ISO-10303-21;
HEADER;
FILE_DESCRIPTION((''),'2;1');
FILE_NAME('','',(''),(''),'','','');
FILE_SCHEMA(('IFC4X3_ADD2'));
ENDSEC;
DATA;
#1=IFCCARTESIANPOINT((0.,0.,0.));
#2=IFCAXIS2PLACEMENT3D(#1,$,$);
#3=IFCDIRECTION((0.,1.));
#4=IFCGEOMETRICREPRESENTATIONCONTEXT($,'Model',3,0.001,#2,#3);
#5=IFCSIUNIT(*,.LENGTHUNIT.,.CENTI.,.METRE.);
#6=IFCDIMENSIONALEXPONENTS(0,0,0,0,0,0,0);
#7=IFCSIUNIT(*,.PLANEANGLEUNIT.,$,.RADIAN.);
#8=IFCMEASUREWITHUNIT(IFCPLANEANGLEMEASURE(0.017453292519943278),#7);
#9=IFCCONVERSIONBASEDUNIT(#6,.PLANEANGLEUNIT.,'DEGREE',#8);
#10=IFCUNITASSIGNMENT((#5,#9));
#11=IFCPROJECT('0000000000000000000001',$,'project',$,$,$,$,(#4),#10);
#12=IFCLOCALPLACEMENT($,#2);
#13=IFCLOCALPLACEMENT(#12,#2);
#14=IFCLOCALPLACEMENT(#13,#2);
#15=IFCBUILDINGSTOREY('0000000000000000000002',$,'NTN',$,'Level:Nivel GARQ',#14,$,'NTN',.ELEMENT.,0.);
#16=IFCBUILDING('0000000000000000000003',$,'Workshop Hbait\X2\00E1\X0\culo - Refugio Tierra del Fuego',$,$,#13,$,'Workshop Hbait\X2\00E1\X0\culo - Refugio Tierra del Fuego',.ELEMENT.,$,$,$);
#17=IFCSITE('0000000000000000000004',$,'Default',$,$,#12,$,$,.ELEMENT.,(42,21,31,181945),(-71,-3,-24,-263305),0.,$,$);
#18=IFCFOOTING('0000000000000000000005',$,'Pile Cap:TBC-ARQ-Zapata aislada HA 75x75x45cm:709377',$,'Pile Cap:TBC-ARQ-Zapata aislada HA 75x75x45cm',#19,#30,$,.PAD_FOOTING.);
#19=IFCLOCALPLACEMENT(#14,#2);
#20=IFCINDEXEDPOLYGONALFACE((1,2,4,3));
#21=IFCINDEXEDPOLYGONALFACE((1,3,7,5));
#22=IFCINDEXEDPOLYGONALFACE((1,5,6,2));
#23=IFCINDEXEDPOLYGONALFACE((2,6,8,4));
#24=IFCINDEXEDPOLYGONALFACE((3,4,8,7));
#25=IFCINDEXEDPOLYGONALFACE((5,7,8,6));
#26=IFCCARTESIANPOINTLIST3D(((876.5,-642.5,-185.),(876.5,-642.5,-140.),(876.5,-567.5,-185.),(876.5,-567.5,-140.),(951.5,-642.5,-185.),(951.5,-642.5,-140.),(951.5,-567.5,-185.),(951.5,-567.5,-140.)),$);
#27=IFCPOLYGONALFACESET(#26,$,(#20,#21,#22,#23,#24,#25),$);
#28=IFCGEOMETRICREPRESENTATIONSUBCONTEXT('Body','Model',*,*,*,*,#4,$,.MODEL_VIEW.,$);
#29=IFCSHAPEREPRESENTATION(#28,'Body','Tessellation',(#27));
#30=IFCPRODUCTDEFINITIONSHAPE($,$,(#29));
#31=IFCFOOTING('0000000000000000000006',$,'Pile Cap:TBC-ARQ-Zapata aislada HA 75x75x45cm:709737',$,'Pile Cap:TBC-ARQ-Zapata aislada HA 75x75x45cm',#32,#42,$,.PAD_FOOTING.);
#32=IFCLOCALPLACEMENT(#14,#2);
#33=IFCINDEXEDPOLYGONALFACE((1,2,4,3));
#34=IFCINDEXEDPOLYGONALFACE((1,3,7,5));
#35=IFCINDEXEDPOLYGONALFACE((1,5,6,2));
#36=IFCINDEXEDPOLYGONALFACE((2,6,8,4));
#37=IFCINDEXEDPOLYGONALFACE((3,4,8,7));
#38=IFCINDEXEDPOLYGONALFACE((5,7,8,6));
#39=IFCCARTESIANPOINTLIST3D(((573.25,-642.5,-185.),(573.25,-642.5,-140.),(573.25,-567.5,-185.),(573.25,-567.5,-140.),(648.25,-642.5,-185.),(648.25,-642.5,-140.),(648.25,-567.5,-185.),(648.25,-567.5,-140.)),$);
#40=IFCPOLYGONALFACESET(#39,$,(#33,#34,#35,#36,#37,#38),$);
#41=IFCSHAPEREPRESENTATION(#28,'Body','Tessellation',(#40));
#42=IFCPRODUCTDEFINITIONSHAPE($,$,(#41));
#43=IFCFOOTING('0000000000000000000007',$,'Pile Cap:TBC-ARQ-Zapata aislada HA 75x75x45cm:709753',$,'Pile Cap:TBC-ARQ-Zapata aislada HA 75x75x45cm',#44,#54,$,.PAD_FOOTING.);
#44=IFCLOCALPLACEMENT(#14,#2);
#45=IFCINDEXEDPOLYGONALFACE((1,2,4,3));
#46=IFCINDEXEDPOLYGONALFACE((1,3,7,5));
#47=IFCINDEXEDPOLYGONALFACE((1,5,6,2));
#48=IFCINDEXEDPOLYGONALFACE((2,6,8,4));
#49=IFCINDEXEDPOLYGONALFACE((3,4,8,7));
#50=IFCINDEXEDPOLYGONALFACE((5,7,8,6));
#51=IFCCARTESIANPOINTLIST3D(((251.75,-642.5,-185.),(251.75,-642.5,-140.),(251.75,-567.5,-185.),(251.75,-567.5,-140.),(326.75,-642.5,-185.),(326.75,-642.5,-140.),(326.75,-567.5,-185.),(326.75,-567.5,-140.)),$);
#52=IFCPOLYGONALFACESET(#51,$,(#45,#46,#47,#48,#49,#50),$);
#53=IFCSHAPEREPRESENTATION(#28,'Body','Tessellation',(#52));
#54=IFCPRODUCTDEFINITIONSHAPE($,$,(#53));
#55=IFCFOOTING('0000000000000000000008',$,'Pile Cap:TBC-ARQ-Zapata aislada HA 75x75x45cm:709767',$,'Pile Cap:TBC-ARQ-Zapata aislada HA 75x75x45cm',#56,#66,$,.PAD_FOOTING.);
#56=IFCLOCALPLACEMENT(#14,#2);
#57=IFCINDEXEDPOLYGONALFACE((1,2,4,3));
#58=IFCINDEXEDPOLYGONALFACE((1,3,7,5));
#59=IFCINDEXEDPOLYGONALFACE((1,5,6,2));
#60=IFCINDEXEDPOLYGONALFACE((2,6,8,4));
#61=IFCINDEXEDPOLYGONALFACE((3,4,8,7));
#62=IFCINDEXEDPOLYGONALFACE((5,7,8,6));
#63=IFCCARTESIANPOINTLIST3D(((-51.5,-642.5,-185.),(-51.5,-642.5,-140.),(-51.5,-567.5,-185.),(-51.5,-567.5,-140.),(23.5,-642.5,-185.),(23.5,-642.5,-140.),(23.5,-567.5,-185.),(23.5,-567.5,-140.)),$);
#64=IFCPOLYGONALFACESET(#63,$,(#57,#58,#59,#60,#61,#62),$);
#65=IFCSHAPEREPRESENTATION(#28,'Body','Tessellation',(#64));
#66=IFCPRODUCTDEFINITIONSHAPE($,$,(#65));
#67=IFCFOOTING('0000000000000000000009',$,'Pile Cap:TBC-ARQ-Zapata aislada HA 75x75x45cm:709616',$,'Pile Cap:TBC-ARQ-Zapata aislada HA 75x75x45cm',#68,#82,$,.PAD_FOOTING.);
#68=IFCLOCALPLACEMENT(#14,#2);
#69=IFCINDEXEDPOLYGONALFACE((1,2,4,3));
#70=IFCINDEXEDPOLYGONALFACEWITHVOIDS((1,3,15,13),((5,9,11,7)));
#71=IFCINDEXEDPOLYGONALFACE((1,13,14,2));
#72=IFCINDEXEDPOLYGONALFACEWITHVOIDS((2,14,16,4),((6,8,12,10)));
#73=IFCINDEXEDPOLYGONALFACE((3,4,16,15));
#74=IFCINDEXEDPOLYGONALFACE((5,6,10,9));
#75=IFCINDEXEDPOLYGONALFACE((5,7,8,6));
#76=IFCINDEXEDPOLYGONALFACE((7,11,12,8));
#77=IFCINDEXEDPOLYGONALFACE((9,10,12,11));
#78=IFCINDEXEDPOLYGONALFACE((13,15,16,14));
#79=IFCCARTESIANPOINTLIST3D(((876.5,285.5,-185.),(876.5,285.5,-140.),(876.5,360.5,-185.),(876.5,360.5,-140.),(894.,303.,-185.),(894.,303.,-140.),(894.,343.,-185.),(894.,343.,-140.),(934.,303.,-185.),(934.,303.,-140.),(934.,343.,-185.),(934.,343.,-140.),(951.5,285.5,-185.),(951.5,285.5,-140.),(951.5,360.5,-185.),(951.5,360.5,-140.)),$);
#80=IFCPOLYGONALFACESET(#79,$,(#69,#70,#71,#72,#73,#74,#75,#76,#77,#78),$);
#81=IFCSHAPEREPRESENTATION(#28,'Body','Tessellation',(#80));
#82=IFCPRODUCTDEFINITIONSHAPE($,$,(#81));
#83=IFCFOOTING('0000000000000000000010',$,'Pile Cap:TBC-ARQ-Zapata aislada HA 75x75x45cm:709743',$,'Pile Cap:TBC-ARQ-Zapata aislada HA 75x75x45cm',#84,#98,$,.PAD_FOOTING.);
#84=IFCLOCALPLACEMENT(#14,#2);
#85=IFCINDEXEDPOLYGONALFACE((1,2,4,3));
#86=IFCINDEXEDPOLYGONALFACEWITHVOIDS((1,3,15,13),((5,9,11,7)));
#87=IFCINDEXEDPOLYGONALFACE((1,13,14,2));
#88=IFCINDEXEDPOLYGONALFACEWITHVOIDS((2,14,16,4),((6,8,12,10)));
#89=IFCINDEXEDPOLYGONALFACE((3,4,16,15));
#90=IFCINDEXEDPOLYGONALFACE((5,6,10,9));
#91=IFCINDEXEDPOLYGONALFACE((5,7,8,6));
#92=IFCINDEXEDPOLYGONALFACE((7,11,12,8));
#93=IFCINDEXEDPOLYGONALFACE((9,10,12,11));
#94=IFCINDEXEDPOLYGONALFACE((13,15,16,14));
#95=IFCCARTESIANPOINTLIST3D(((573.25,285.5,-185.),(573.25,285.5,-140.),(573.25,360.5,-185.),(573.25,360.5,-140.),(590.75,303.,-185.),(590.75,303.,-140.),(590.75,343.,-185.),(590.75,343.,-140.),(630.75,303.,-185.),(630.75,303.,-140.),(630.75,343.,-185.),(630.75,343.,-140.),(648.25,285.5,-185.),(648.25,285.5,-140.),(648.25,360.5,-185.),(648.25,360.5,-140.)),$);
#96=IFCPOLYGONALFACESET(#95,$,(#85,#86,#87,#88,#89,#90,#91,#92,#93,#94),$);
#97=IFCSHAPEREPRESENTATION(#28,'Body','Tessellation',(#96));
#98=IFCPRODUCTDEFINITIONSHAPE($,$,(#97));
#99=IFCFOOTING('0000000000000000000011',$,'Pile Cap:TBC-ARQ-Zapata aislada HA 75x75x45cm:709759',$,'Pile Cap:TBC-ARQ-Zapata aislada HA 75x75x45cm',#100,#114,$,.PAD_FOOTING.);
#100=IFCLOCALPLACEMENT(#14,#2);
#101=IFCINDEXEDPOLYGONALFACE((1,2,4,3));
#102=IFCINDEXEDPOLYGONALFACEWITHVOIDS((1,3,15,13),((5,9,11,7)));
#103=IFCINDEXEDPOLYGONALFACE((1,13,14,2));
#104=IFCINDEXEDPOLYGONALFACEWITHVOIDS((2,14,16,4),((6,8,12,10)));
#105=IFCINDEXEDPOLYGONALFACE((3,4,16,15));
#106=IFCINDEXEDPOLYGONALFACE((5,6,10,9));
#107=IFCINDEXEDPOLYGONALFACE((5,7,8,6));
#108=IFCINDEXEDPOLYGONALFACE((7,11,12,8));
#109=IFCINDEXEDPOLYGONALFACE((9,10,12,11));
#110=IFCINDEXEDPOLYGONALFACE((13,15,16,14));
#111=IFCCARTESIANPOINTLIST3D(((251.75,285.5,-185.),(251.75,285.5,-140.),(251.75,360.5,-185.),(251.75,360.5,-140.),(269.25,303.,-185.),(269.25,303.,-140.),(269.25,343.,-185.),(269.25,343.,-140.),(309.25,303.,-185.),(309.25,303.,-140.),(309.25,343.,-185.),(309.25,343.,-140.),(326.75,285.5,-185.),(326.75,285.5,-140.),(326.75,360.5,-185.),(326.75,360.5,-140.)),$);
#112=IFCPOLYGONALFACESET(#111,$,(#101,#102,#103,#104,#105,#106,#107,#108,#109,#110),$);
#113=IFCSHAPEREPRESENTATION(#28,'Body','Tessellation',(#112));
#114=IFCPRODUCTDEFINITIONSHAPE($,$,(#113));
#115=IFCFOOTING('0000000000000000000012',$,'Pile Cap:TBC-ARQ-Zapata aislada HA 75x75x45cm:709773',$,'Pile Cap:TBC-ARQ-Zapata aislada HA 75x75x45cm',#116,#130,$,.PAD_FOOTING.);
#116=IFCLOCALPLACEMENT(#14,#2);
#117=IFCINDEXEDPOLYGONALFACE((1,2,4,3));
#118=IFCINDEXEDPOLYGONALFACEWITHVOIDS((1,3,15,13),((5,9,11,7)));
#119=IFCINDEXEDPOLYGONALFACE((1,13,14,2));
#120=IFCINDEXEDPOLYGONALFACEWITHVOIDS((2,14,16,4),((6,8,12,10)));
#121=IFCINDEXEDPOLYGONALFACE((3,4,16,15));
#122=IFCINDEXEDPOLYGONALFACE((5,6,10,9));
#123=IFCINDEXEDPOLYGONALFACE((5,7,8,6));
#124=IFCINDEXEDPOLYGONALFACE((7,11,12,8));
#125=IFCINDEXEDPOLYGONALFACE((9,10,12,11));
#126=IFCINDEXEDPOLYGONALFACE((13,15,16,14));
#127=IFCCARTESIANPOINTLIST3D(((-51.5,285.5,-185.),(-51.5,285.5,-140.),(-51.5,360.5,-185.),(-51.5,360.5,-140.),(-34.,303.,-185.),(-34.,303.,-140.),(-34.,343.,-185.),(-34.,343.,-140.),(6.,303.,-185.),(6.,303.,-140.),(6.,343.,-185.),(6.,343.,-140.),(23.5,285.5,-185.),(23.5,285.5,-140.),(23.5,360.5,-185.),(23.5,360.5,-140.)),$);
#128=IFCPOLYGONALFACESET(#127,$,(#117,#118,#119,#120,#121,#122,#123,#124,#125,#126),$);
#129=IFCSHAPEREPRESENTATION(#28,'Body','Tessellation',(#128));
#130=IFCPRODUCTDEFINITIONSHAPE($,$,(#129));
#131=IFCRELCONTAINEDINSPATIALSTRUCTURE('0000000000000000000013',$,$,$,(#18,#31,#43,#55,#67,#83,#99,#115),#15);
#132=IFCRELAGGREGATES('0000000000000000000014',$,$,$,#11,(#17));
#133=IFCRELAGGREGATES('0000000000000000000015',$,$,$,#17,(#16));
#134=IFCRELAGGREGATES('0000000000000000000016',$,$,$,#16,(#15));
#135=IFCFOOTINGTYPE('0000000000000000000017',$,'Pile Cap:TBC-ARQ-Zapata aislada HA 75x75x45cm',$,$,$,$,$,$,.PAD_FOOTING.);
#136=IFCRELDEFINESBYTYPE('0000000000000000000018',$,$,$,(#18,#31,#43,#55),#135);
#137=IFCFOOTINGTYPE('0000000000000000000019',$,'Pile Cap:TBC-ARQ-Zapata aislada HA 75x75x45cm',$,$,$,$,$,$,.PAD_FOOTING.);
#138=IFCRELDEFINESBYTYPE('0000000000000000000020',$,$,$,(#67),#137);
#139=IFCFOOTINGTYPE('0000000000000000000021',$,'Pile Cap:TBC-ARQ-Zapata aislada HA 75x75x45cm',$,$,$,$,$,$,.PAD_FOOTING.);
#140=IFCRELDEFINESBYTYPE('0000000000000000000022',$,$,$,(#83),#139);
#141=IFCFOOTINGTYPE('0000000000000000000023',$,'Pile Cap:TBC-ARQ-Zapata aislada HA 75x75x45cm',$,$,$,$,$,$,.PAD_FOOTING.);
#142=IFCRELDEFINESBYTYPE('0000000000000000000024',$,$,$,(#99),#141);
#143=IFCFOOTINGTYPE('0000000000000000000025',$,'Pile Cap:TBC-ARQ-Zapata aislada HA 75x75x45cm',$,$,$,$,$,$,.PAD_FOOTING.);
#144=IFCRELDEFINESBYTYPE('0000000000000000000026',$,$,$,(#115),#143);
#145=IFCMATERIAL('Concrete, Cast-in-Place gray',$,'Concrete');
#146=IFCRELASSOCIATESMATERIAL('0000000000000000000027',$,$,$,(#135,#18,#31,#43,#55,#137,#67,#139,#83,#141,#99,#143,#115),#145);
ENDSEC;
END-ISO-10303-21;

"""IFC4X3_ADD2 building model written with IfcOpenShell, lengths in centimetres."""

from ifc_helpers import new_model, entity, si_unit, converted_unit, direction, frame, origin, origin_2d_with_axis, place, context, subcontext, project, spatial, polyline, rectangle, outline, extrude, source, transform, mapped, material, type_object, type_shapes, element, save


model = new_model("IFC4X3_ADD2")

# Units and contexts
model_context = context("Model", 3, precision=0.001, world=origin(), true_north=direction((0.0, 1.0)))
body_context = subcontext(model_context, "Body", "Model", "MODEL_VIEW")
ifc_project = project(units=[si_unit("LENGTHUNIT", "METRE", prefix="CENTI"), converted_unit("PLANEANGLEUNIT", "DEGREE", entity("IfcPlaneAngleMeasure", 0.017453292519943278), si_unit("PLANEANGLEUNIT", "RADIAN"), dimensions=[0, 0, 0, 0, 0, 0, 0])], contexts=[model_context])

# Site, building, storey
site_placement = place(None, origin())
site = spatial("IfcSite", under=ifc_project, at=site_placement, Name="Default", CompositionType="ELEMENT", RefLatitude=(42, 21, 31, 181945), RefLongitude=(-71, -3, -24, -263305), RefElevation=0.0)
building_placement = place(site_placement, origin())
building = spatial("IfcBuilding", under=site, at=building_placement, Name="Workshop Hbaitáculo - Refugio Tierra del Fuego", LongName="Workshop Hbaitáculo - Refugio Tierra del Fuego", CompositionType="ELEMENT")
storey_placement = place(building_placement, origin())
storey = spatial("IfcBuildingStorey", under=building, at=storey_placement, Name="NTN", ObjectType="Level:Nivel GARQ", LongName="NTN", CompositionType="ELEMENT", Elevation=0.0)

# Footings
ifc_material_1 = material(Name="Concrete, Cast-in-Place gray", Category="Concrete")
footing_type_1 = type_object("IfcFootingType", Name="Pile Cap:TBC-ARQ-Zapata aislada HA 75x75x45cm", PredefinedType="PAD_FOOTING", material=ifc_material_1)
shared_shape_1 = source(origin(), body_context, "Body", "SweptSolid", [
    extrude(rectangle(XDim=75.0, YDim=75.0, at=origin_2d_with_axis()), frame((0.0, 0.0, -45.0), z_axis=(0.0, 0.0, 1.0), x_axis=(-1.0, 0.0, 0.0)), (0.0, 0.0, 1.0), 45.0),
])
type_shapes(footing_type_1, [shared_shape_1])
for number, where, name in (
    (1, (914.0, -605.0, -140.0), "Pile Cap:TBC-ARQ-Zapata aislada HA 75x75x45cm:709377"),
    (2, (610.75, -605.0, -140.0), "Pile Cap:TBC-ARQ-Zapata aislada HA 75x75x45cm:709737"),
    (3, (289.25, -605.0, -140.0), "Pile Cap:TBC-ARQ-Zapata aislada HA 75x75x45cm:709753"),
    (4, (-14.0, -605.0, -140.0), "Pile Cap:TBC-ARQ-Zapata aislada HA 75x75x45cm:709767"),
):
    element("IfcFooting", number, at=place(storey_placement, frame(where)), inside=storey, type_object=footing_type_1, material=ifc_material_1, Name=name, ObjectType="Pile Cap:TBC-ARQ-Zapata aislada HA 75x75x45cm", PredefinedType="PAD_FOOTING", context=body_context, shape_type="MappedRepresentation", body=[
        mapped(shared_shape_1, transform((0.0, 0.0, 0.0), scale=1.0)),
    ])
footing_type_2 = type_object("IfcFootingType", Name="Pile Cap:TBC-ARQ-Zapata aislada HA 75x75x45cm", PredefinedType="PAD_FOOTING", material=ifc_material_1)
shared_shape_2 = source(origin(), body_context, "Body", "SweptSolid", [
    extrude(outline(polyline([(-37.5, -37.5), (37.5, -37.5), (37.5, 37.5), (-37.5, 37.5), (-37.5, -37.5)]), holes=[polyline([(-20.0, -20.0), (-20.0, 20.0), (20.0, 20.0), (20.0, -20.0), (-20.0, -20.0)])]), frame((914.0, 323.0, -45.0), z_axis=(0.0, 0.0, 1.0), x_axis=(-1.0, 0.0, 0.0)), (0.0, 0.0, 1.0), 45.0),
])
type_shapes(footing_type_2, [shared_shape_2])
footing_1_placement = place(storey_placement, frame((0.0, 0.0, -140.0)))
element("IfcFooting", 5, at=footing_1_placement, inside=storey, type_object=footing_type_2, material=ifc_material_1, Name="Pile Cap:TBC-ARQ-Zapata aislada HA 75x75x45cm:709616", ObjectType="Pile Cap:TBC-ARQ-Zapata aislada HA 75x75x45cm", PredefinedType="PAD_FOOTING", context=body_context, shape_type="MappedRepresentation", body=[
    mapped(shared_shape_2, transform((0.0, 0.0, 0.0), scale=1.0)),
])
footing_type_3 = type_object("IfcFootingType", Name="Pile Cap:TBC-ARQ-Zapata aislada HA 75x75x45cm", PredefinedType="PAD_FOOTING", material=ifc_material_1)
shared_shape_3 = source(origin(), body_context, "Body", "SweptSolid", [
    extrude(outline(polyline([(-37.5, -37.5), (37.5, -37.5), (37.5, 37.5), (-37.5, 37.5), (-37.5, -37.5)]), holes=[polyline([(-20.0, -20.0), (-20.0, 20.0), (20.0, 20.0), (20.0, -20.0), (-20.0, -20.0)])]), frame((610.75, 323.0, -45.0), z_axis=(0.0, 0.0, 1.0), x_axis=(-1.0, 0.0, 0.0)), (0.0, 0.0, 1.0), 45.0),
])
type_shapes(footing_type_3, [shared_shape_3])
footing_2_placement = place(storey_placement, frame((0.0, 0.0, -140.0)))
element("IfcFooting", 6, at=footing_2_placement, inside=storey, type_object=footing_type_3, material=ifc_material_1, Name="Pile Cap:TBC-ARQ-Zapata aislada HA 75x75x45cm:709743", ObjectType="Pile Cap:TBC-ARQ-Zapata aislada HA 75x75x45cm", PredefinedType="PAD_FOOTING", context=body_context, shape_type="MappedRepresentation", body=[
    mapped(shared_shape_3, transform((0.0, 0.0, 0.0), scale=1.0)),
])
footing_type_4 = type_object("IfcFootingType", Name="Pile Cap:TBC-ARQ-Zapata aislada HA 75x75x45cm", PredefinedType="PAD_FOOTING", material=ifc_material_1)
shared_shape_4 = source(origin(), body_context, "Body", "SweptSolid", [
    extrude(outline(polyline([(-37.5, -37.5), (37.5, -37.5), (37.5, 37.5), (-37.5, 37.5), (-37.5, -37.5)]), holes=[polyline([(-20.0, -20.0), (-20.0, 20.0), (20.0, 20.0), (20.0, -20.0), (-20.0, -20.0)])]), frame((289.25, 323.0, -45.0), z_axis=(0.0, 0.0, 1.0), x_axis=(-1.0, 0.0, 0.0)), (0.0, 0.0, 1.0), 45.0),
])
type_shapes(footing_type_4, [shared_shape_4])
footing_3_placement = place(storey_placement, frame((0.0, 0.0, -140.0)))
element("IfcFooting", 7, at=footing_3_placement, inside=storey, type_object=footing_type_4, material=ifc_material_1, Name="Pile Cap:TBC-ARQ-Zapata aislada HA 75x75x45cm:709759", ObjectType="Pile Cap:TBC-ARQ-Zapata aislada HA 75x75x45cm", PredefinedType="PAD_FOOTING", context=body_context, shape_type="MappedRepresentation", body=[
    mapped(shared_shape_4, transform((0.0, 0.0, 0.0), scale=1.0)),
])
footing_type_5 = type_object("IfcFootingType", Name="Pile Cap:TBC-ARQ-Zapata aislada HA 75x75x45cm", PredefinedType="PAD_FOOTING", material=ifc_material_1)
shared_shape_5 = source(origin(), body_context, "Body", "SweptSolid", [
    extrude(outline(polyline([(-37.5, -37.5), (37.5, -37.5), (37.5, 37.5), (-37.5, 37.5), (-37.5, -37.5)]), holes=[polyline([(-20.0, -20.0), (-20.0, 20.0), (20.0, 20.0), (20.0, -20.0), (-20.0, -20.0)])]), frame((-14.0, 323.0, -45.0), z_axis=(0.0, 0.0, 1.0), x_axis=(-1.0, 0.0, 0.0)), (0.0, 0.0, 1.0), 45.0),
])
type_shapes(footing_type_5, [shared_shape_5])
footing_4_placement = place(storey_placement, frame((0.0, 0.0, -140.0)))
element("IfcFooting", 8, at=footing_4_placement, inside=storey, type_object=footing_type_5, material=ifc_material_1, Name="Pile Cap:TBC-ARQ-Zapata aislada HA 75x75x45cm:709773", ObjectType="Pile Cap:TBC-ARQ-Zapata aislada HA 75x75x45cm", PredefinedType="PAD_FOOTING", context=body_context, shape_type="MappedRepresentation", body=[
    mapped(shared_shape_5, transform((0.0, 0.0, 0.0), scale=1.0)),
])

save(model, "model.ifc")
